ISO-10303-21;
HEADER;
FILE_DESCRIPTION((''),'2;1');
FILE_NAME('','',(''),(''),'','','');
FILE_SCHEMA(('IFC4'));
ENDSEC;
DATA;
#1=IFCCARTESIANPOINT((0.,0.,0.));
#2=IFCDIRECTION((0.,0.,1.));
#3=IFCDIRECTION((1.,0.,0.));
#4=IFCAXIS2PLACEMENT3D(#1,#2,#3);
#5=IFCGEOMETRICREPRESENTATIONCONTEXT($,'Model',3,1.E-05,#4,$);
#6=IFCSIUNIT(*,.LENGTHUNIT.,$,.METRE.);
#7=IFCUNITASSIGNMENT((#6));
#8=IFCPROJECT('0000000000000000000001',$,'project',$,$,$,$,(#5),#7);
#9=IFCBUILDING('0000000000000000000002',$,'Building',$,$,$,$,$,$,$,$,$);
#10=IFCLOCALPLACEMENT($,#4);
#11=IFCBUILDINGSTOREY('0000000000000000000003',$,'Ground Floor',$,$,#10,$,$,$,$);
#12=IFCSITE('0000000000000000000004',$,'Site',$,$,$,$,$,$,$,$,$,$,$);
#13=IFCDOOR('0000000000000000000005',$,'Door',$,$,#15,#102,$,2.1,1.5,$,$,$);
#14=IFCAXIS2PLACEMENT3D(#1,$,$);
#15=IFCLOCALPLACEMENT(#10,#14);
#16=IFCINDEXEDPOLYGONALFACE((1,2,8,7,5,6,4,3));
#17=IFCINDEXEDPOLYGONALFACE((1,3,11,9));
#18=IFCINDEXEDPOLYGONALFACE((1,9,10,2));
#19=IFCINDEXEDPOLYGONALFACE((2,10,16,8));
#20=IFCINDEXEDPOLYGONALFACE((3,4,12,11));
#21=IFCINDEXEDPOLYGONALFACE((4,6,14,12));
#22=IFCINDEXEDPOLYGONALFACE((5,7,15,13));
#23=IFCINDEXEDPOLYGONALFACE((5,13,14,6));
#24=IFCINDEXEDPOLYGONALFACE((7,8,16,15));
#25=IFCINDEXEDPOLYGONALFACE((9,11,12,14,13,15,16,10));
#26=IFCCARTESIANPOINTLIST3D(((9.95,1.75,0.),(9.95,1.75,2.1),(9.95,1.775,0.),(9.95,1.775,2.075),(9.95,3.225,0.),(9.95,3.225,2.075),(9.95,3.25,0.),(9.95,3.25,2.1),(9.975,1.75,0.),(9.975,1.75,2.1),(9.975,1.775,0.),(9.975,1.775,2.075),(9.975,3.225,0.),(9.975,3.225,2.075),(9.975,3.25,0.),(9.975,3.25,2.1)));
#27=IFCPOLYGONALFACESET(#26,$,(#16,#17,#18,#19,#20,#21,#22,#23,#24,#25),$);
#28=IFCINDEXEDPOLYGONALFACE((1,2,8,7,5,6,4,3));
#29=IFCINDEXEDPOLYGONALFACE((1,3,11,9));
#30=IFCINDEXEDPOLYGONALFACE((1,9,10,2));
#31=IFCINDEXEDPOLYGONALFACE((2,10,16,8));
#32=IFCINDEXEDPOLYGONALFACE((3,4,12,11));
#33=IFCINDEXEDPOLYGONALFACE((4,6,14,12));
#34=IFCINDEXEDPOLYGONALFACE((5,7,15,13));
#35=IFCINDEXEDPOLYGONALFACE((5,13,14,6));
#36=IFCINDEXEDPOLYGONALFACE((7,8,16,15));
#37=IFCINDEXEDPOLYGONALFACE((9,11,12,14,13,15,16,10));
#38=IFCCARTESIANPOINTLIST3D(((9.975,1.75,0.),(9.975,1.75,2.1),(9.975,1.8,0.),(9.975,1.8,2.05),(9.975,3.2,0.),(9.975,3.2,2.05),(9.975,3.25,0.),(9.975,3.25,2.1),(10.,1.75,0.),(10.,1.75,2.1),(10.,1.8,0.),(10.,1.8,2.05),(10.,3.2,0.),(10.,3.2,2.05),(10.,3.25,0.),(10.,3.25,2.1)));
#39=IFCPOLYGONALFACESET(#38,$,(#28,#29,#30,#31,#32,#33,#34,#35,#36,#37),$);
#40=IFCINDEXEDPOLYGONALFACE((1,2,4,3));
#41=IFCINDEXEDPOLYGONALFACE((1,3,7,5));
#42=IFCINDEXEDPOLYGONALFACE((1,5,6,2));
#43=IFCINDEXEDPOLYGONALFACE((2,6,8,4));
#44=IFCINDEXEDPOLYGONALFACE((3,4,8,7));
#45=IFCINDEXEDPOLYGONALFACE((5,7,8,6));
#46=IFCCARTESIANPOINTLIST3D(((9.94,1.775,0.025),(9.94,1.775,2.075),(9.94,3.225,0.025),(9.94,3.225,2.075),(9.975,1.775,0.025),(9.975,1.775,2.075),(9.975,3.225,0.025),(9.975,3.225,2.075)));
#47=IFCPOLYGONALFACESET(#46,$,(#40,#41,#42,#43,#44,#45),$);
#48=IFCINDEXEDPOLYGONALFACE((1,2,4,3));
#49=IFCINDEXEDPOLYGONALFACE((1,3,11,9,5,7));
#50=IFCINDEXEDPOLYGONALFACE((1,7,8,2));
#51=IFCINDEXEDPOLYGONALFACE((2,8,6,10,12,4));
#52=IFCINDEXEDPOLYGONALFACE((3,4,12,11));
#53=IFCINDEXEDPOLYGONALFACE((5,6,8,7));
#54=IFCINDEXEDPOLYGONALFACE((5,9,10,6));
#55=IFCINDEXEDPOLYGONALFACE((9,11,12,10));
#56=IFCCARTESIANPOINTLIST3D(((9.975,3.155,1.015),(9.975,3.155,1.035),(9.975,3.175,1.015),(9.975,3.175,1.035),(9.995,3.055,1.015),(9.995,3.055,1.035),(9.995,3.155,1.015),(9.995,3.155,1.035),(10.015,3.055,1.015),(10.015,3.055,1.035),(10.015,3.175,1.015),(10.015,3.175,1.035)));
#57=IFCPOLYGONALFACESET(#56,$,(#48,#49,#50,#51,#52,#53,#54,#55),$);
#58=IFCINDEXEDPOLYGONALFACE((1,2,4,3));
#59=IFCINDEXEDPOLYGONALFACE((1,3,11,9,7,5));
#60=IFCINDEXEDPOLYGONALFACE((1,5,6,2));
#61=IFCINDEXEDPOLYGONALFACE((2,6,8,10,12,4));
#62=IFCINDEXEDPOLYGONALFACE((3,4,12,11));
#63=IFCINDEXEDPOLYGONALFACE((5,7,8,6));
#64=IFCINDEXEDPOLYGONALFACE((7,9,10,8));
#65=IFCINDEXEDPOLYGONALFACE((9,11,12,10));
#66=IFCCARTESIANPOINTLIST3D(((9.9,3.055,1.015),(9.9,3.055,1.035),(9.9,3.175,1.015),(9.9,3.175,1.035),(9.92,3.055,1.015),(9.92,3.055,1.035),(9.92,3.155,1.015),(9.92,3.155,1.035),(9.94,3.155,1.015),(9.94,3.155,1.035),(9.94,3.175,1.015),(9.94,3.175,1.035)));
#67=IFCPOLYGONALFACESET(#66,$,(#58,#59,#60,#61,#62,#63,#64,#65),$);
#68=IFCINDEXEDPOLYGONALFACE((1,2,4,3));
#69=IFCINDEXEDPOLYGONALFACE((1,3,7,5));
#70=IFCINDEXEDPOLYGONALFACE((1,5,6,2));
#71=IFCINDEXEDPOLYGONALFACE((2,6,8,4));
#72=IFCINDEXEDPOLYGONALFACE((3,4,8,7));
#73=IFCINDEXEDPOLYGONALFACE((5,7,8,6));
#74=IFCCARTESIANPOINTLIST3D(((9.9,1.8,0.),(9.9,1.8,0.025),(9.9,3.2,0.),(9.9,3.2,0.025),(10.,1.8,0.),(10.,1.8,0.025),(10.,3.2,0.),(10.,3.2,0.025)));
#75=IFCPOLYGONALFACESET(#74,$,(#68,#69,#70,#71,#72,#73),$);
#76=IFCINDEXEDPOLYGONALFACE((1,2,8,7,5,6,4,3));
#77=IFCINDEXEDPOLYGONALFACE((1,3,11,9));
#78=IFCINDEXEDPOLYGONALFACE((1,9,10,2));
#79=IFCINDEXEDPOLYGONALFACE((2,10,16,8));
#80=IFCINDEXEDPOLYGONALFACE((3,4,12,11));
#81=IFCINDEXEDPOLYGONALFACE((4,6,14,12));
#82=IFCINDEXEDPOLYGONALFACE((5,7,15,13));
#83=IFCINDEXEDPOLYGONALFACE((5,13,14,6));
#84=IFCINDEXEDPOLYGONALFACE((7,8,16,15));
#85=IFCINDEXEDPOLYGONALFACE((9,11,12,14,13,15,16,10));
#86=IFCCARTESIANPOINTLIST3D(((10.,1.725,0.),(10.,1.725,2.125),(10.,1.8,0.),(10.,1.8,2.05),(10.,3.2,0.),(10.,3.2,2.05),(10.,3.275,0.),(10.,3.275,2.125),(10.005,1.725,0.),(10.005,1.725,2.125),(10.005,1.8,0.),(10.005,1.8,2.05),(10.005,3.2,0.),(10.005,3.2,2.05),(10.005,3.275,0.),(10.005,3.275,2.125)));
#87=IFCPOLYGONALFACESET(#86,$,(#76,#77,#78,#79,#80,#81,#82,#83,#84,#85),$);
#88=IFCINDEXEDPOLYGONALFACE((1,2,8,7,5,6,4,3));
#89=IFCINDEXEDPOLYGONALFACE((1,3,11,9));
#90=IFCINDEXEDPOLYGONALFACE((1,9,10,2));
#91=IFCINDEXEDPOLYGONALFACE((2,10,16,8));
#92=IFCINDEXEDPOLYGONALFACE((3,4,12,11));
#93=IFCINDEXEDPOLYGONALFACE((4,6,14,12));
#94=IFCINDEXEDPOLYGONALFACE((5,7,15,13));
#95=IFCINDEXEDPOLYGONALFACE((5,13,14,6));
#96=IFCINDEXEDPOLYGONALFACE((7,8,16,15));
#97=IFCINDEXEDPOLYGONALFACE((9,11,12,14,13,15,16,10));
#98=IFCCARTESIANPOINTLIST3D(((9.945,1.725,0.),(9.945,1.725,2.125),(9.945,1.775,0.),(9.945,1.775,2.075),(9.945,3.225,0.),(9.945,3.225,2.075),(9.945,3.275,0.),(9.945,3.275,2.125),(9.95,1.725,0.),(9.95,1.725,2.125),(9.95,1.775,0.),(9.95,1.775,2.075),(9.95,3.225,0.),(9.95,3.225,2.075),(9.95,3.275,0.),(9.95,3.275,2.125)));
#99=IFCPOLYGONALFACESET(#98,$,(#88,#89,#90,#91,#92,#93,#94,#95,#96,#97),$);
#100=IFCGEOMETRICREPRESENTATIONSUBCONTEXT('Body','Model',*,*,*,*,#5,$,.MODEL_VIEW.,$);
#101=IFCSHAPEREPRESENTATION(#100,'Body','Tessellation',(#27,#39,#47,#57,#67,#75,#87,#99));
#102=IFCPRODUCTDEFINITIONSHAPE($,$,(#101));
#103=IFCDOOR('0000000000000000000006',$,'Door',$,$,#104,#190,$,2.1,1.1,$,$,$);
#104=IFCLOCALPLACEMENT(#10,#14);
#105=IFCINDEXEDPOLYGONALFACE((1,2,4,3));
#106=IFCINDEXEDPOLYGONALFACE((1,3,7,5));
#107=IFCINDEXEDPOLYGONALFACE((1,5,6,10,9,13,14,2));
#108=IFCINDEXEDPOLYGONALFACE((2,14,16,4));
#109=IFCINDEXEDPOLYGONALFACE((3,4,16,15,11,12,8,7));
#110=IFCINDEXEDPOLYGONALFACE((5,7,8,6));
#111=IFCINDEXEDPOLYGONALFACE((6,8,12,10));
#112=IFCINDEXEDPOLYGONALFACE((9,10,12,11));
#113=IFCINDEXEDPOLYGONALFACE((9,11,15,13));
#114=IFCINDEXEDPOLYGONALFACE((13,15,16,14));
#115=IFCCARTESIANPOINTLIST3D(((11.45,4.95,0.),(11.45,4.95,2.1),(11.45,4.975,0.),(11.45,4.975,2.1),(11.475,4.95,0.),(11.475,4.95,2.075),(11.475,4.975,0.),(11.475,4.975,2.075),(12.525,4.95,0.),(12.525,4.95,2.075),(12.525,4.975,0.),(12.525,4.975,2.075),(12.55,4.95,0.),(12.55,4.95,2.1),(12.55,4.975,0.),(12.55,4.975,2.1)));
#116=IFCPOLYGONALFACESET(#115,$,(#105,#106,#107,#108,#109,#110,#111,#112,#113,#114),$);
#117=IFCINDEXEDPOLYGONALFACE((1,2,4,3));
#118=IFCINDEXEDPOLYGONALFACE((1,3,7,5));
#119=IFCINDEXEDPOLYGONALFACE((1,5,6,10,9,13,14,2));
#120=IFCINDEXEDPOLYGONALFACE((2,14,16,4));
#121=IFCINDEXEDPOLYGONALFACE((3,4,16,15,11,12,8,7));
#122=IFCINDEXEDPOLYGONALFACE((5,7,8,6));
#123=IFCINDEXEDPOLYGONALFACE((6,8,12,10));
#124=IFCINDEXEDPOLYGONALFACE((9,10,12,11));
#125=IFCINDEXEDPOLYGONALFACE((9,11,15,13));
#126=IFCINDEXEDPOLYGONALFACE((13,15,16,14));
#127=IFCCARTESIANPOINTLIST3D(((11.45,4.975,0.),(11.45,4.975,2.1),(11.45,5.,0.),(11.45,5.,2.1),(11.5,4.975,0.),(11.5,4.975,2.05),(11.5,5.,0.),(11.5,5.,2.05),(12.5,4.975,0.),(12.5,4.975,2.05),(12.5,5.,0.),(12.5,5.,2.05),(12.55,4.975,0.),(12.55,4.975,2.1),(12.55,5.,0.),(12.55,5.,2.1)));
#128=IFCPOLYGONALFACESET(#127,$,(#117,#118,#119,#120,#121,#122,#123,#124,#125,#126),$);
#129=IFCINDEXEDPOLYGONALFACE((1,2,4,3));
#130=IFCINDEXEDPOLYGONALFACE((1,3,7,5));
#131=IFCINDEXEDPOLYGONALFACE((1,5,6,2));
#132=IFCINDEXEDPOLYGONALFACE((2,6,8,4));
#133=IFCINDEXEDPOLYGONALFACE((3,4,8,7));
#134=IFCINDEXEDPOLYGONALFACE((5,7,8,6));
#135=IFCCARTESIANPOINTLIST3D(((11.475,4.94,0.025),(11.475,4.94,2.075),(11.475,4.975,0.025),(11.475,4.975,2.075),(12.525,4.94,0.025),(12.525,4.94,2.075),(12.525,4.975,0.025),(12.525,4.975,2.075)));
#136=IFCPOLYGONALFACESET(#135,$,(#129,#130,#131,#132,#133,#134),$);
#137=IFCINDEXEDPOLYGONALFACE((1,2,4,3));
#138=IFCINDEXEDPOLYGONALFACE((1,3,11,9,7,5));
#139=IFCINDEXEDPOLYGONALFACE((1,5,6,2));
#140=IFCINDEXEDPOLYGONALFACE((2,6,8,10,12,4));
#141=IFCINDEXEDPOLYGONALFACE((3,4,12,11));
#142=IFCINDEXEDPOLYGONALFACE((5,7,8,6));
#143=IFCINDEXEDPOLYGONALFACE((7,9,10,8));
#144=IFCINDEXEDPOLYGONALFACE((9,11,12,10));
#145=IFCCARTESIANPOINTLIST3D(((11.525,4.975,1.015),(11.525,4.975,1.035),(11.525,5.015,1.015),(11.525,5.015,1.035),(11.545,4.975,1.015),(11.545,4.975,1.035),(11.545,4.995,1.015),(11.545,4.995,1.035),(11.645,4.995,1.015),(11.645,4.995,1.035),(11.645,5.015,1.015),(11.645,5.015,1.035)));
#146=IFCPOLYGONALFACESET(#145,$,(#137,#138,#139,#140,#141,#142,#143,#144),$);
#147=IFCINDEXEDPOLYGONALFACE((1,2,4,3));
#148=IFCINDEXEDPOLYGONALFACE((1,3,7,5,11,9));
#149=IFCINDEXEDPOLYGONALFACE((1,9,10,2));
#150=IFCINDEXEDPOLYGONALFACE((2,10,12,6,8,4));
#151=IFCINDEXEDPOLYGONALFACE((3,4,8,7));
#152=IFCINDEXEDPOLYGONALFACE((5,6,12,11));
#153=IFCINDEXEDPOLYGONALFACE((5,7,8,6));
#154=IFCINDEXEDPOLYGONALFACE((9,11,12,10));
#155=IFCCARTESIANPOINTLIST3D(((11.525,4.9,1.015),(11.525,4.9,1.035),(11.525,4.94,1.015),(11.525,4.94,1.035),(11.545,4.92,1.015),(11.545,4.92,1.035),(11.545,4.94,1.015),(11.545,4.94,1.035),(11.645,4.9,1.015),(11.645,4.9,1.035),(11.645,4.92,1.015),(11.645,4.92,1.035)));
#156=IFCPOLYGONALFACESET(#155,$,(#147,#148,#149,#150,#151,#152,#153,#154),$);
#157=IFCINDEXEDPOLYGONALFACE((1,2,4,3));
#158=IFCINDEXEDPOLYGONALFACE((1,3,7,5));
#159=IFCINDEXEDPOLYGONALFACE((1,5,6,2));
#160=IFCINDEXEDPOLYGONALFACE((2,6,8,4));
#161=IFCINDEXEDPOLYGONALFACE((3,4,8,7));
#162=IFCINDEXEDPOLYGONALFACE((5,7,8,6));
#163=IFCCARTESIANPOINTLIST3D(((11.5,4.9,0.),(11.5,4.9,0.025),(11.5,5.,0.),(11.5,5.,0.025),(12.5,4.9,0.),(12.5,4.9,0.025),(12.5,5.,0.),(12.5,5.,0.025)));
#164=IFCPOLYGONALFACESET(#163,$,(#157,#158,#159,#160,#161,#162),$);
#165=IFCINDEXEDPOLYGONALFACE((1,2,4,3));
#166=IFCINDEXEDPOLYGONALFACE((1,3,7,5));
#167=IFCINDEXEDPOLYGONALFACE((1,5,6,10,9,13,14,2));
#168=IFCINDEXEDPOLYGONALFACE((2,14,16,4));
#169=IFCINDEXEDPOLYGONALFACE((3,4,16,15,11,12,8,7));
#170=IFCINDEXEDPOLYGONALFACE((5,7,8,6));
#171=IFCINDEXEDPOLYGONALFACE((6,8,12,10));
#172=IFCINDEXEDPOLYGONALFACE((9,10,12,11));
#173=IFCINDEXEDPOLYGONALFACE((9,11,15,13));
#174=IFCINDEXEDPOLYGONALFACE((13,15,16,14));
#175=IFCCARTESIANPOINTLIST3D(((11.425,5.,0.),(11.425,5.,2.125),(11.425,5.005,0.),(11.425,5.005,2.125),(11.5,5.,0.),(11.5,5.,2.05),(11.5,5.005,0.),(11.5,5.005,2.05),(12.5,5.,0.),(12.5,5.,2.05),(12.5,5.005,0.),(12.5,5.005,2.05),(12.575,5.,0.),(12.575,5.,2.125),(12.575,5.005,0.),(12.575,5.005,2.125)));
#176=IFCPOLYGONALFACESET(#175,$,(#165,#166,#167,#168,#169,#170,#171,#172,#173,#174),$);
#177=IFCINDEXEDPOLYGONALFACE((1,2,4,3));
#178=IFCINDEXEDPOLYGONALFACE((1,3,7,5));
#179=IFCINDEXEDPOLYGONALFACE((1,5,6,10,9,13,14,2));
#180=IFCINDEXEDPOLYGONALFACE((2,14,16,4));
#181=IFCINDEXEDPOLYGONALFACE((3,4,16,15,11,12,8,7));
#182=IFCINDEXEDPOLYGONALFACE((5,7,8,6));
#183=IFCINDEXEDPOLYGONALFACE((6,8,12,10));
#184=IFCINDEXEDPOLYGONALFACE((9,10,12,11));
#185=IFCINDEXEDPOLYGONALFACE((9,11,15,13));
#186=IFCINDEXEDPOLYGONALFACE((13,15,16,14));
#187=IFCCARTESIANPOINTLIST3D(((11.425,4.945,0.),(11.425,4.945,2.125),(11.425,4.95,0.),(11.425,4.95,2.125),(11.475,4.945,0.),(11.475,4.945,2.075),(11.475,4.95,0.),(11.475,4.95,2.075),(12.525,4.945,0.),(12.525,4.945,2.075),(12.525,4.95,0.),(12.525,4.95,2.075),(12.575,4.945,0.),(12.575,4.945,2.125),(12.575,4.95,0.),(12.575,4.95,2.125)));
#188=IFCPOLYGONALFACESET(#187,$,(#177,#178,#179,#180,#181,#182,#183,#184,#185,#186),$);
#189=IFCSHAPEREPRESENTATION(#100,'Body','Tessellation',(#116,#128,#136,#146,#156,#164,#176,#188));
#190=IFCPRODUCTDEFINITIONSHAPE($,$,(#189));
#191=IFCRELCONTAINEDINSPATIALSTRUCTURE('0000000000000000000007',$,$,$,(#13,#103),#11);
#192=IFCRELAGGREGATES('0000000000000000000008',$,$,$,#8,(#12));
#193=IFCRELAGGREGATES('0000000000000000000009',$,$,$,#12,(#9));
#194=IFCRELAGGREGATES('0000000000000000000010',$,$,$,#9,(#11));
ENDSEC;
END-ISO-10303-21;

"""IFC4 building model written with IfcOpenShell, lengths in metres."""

from ifc_helpers import new_model, si_unit, frame, origin_with_axes, place, context, subcontext, project, spatial, line, indexed_curve, outline, extrude, element, save


model = new_model("IFC4")

# Units and contexts
model_context = context("Model", 3, precision=1e-05, world=origin_with_axes())
body_context = subcontext(model_context, "Body", "Model", "MODEL_VIEW")
ifc_project = project(units=[si_unit("LENGTHUNIT", "METRE")], contexts=[model_context])

# Site, building, storey
site = spatial("IfcSite", under=ifc_project, Name="Site")
building = spatial("IfcBuilding", under=site, Name="Building")
storey_placement = place(None, origin_with_axes())
storey = spatial("IfcBuildingStorey", under=building, at=storey_placement, Name="Ground Floor")

# Doors
door_1_placement = place(storey_placement, frame((10.0, 1.75, 0.0), z_axis=(0.0, 0.0, 1.0), x_axis=(0.0, 1.0, 0.0)))
element("IfcDoor", 1, at=door_1_placement, inside=storey, Name="Door", OverallHeight=2.1, OverallWidth=1.5, context=body_context, shape_type="SweptSolid", body=[
    extrude(outline(indexed_curve([(0.0, 0.0), (0.0, 2.1), (1.5, 2.1), (1.5, 0.0), (1.475, 0.0), (1.475, 2.075), (0.025, 2.075), (0.025, 0.0)], segments=[line(1, 2, 3, 4, 5, 6, 7, 8, 1)])), frame((0.0, 0.025, 0.0), z_axis=(0.0, -1.0, 0.0), x_axis=(1.0, 0.0, 0.0)), (0.0, 0.0, -1.0), 0.025),
    extrude(outline(indexed_curve([(0.0, 0.0), (0.0, 2.1), (1.5, 2.1), (1.5, 0.0), (1.45, 0.0), (1.45, 2.05), (0.05, 2.05), (0.05, 0.0)], segments=[line(1, 2, 3, 4, 5, 6, 7, 8, 1)])), frame((0.0, 0.0, 0.0), z_axis=(0.0, -1.0, 0.0), x_axis=(1.0, 0.0, 0.0)), (0.0, 0.0, -1.0), 0.025),
    extrude(outline(indexed_curve([(0.0, 0.0), (1.45, 0.0), (1.45, 0.035), (0.0, 0.035)], segments=[line(1, 2, 3, 4, 1)])), frame((0.025, 0.025, 0.025), z_axis=(0.0, 0.0, 1.0), x_axis=(1.0, 0.0, 0.0)), (0.0, 0.0, 1.0), 2.05),
    extrude(outline(indexed_curve([(0.0, 0.0), (0.0, -0.04), (-0.12, -0.04), (-0.12, -0.02), (-0.02, -0.02), (-0.02, 0.0)], segments=[line(1, 2, 3, 4, 5, 6, 1)])), frame((1.425, 0.025, 1.015), z_axis=(0.0, 0.0, 1.0), x_axis=(1.0, 0.0, 0.0)), (0.0, 0.0, 1.0), 0.02),
    extrude(outline(indexed_curve([(0.0, 0.0), (0.0, 0.04), (-0.12, 0.04), (-0.12, 0.02), (-0.02, 0.02), (-0.02, 0.0)], segments=[line(1, 2, 3, 4, 5, 6, 1)])), frame((1.425, 0.06, 1.015), z_axis=(0.0, 0.0, 1.0), x_axis=(1.0, 0.0, 0.0)), (0.0, 0.0, 1.0), 0.02),
    extrude(outline(indexed_curve([(0.0, 0.0), (1.4, 0.0), (1.4, 0.1), (0.0, 0.1)], segments=[line(1, 2, 3, 4, 1)])), frame((0.05, 0.0, 0.0), z_axis=(0.0, 0.0, 1.0), x_axis=(1.0, 0.0, 0.0)), (0.0, 0.0, 1.0), 0.025),
    extrude(outline(indexed_curve([(0.0, 0.0), (0.0, 2.125), (1.55, 2.125), (1.55, 0.0), (1.475, 0.0), (1.475, 2.05), (0.075, 2.05), (0.075, 0.0)], segments=[line(1, 2, 3, 4, 5, 6, 7, 8, 1)])), frame((-0.025, -0.005, 0.0), z_axis=(0.0, -1.0, 0.0), x_axis=(1.0, 0.0, 0.0)), (0.0, 0.0, -1.0), 0.005),
    extrude(outline(indexed_curve([(0.0, 0.0), (0.0, 2.125), (1.55, 2.125), (1.55, 0.0), (1.5, 0.0), (1.5, 2.075), (0.05, 2.075), (0.05, 0.0)], segments=[line(1, 2, 3, 4, 5, 6, 7, 8, 1)])), frame((-0.025, 0.05, 0.0), z_axis=(0.0, -1.0, 0.0), x_axis=(1.0, 0.0, 0.0)), (0.0, 0.0, -1.0), 0.005),
])
door_2_placement = place(storey_placement, frame((12.55, 5.0, 0.0), z_axis=(0.0, 0.0, 1.0), x_axis=(-1.0, 0.0, 0.0)))
element("IfcDoor", 2, at=door_2_placement, inside=storey, Name="Door", OverallHeight=2.1, OverallWidth=1.1, context=body_context, shape_type="SweptSolid", body=[
    extrude(outline(indexed_curve([(0.0, 0.0), (0.0, 2.1), (1.1, 2.1), (1.1, 0.0), (1.075, 0.0), (1.075, 2.075), (0.025, 2.075), (0.025, 0.0)], segments=[line(1, 2, 3, 4, 5, 6, 7, 8, 1)])), frame((0.0, 0.025, 0.0), z_axis=(0.0, -1.0, 0.0), x_axis=(1.0, 0.0, 0.0)), (0.0, 0.0, -1.0), 0.025),
    extrude(outline(indexed_curve([(0.0, 0.0), (0.0, 2.1), (1.1, 2.1), (1.1, 0.0), (1.05, 0.0), (1.05, 2.05), (0.05, 2.05), (0.05, 0.0)], segments=[line(1, 2, 3, 4, 5, 6, 7, 8, 1)])), frame((0.0, 0.0, 0.0), z_axis=(0.0, -1.0, 0.0), x_axis=(1.0, 0.0, 0.0)), (0.0, 0.0, -1.0), 0.025),
    extrude(outline(indexed_curve([(0.0, 0.0), (1.05, 0.0), (1.05, 0.035), (0.0, 0.035)], segments=[line(1, 2, 3, 4, 1)])), frame((0.025, 0.025, 0.025), z_axis=(0.0, 0.0, 1.0), x_axis=(1.0, 0.0, 0.0)), (0.0, 0.0, 1.0), 2.05),
    extrude(outline(indexed_curve([(0.0, 0.0), (0.0, -0.04), (-0.12, -0.04), (-0.12, -0.02), (-0.02, -0.02), (-0.02, 0.0)], segments=[line(1, 2, 3, 4, 5, 6, 1)])), frame((1.025, 0.025, 1.015), z_axis=(0.0, 0.0, 1.0), x_axis=(1.0, 0.0, 0.0)), (0.0, 0.0, 1.0), 0.02),
    extrude(outline(indexed_curve([(0.0, 0.0), (0.0, 0.04), (-0.12, 0.04), (-0.12, 0.02), (-0.02, 0.02), (-0.02, 0.0)], segments=[line(1, 2, 3, 4, 5, 6, 1)])), frame((1.025, 0.06, 1.015), z_axis=(0.0, 0.0, 1.0), x_axis=(1.0, 0.0, 0.0)), (0.0, 0.0, 1.0), 0.02),
    extrude(outline(indexed_curve([(0.0, 0.0), (1.0, 0.0), (1.0, 0.1), (0.0, 0.1)], segments=[line(1, 2, 3, 4, 1)])), frame((0.05, 0.0, 0.0), z_axis=(0.0, 0.0, 1.0), x_axis=(1.0, 0.0, 0.0)), (0.0, 0.0, 1.0), 0.025),
    extrude(outline(indexed_curve([(0.0, 0.0), (0.0, 2.125), (1.15, 2.125), (1.15, 0.0), (1.075, 0.0), (1.075, 2.05), (0.075, 2.05), (0.075, 0.0)], segments=[line(1, 2, 3, 4, 5, 6, 7, 8, 1)])), frame((-0.025, -0.005, 0.0), z_axis=(0.0, -1.0, 0.0), x_axis=(1.0, 0.0, 0.0)), (0.0, 0.0, -1.0), 0.005),
    extrude(outline(indexed_curve([(0.0, 0.0), (0.0, 2.125), (1.15, 2.125), (1.15, 0.0), (1.1, 0.0), (1.1, 2.075), (0.05, 2.075), (0.05, 0.0)], segments=[line(1, 2, 3, 4, 5, 6, 7, 8, 1)])), frame((-0.025, 0.05, 0.0), z_axis=(0.0, -1.0, 0.0), x_axis=(1.0, 0.0, 0.0)), (0.0, 0.0, -1.0), 0.005),
])

save(model, "model.ifc")
